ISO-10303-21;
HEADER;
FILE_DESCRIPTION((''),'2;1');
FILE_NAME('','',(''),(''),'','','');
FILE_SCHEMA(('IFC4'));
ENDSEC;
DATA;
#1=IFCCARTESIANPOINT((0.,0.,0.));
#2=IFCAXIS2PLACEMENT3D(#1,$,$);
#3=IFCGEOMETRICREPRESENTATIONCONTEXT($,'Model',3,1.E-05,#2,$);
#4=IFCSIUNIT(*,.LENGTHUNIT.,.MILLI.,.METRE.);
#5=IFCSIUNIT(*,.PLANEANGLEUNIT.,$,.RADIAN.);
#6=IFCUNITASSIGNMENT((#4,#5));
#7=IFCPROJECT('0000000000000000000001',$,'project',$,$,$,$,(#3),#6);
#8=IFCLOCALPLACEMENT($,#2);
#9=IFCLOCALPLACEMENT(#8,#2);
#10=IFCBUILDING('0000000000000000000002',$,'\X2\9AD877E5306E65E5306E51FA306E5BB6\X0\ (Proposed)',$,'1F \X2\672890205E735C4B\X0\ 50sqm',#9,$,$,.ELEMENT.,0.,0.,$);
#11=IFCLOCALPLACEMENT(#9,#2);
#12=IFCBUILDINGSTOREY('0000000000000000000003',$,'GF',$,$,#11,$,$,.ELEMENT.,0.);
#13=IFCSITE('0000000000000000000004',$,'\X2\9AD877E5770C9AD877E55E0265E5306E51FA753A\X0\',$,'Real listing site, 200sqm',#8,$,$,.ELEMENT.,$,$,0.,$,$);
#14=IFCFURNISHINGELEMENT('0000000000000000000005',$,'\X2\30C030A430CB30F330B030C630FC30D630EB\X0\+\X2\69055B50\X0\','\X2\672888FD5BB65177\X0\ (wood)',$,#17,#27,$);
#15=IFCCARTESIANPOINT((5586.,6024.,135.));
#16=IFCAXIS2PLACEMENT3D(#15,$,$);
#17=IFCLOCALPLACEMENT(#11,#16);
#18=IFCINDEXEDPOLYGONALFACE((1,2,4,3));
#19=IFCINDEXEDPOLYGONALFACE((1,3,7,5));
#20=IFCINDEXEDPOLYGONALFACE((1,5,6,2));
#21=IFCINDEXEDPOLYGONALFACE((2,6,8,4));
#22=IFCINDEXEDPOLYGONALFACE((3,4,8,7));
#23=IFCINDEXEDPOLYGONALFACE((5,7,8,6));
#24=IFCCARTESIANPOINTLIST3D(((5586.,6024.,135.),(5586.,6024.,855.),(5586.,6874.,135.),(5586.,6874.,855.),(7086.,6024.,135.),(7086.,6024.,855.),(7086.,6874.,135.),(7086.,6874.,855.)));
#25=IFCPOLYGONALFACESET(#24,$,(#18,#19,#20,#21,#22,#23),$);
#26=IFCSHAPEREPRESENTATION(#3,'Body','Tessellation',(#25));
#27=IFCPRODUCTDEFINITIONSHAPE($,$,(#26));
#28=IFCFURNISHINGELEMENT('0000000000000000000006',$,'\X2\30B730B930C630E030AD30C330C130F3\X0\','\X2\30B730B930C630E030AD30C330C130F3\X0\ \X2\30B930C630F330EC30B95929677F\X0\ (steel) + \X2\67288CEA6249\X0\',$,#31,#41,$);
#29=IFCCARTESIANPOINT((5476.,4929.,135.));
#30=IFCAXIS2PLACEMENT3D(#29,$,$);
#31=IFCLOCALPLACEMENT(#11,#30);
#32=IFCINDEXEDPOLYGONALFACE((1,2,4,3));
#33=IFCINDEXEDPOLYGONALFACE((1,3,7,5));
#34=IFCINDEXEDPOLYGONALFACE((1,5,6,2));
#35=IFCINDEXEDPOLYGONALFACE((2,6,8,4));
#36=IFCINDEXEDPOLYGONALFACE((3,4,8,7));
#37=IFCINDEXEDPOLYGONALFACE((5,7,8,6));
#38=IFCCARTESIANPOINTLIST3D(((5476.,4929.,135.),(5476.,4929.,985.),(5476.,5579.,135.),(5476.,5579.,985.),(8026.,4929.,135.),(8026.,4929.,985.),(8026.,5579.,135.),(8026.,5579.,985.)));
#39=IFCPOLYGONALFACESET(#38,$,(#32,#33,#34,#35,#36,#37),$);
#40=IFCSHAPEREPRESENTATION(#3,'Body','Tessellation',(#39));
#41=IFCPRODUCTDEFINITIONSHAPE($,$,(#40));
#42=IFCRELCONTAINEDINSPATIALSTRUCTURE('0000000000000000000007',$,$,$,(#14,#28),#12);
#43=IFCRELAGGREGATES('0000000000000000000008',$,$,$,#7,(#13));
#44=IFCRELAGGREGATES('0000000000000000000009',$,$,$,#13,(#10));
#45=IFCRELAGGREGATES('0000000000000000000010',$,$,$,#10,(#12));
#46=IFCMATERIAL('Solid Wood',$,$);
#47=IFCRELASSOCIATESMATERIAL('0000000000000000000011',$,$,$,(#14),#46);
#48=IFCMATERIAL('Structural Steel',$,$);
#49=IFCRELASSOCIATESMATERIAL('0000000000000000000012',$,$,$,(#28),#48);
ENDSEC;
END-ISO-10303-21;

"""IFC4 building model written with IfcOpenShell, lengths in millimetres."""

from ifc_helpers import new_model, si_unit, frame, frame_2d, origin, place, context, project, spatial, rectangle, extrude, material, element, save


model = new_model("IFC4")

# Units and contexts
model_context = context("Model", 3, precision=1e-05, world=origin())
ifc_project = project(units=[si_unit("LENGTHUNIT", "METRE", prefix="MILLI"), si_unit("PLANEANGLEUNIT", "RADIAN")], contexts=[model_context])

# Site, building, storey
site_placement = place(None, origin())
site = spatial("IfcSite", under=ifc_project, at=site_placement, Name="高知県高知市日の出町", ObjectType="Real listing site, 200sqm", CompositionType="ELEMENT", RefElevation=0.0)
building_placement = place(site_placement, origin())
building = spatial("IfcBuilding", under=site, at=building_placement, Name="高知の日の出の家 (Proposed)", ObjectType="1F 木造平屋 50sqm", CompositionType="ELEMENT", ElevationOfRefHeight=0.0, ElevationOfTerrain=0.0)
storey_placement = place(building_placement, origin())
storey = spatial("IfcBuildingStorey", under=building, at=storey_placement, Name="GF", CompositionType="ELEMENT", Elevation=0.0)

# Shared definitions
ifc_material_1 = material(Name="Solid Wood")

# Shared definitions
ifc_material_2 = material(Name="Structural Steel")

# Furnishing elements
furnishing_1_placement = place(storey_placement, frame((5586.0, 6024.0, 135.0)))
element("IfcFurnishingElement", 1, at=furnishing_1_placement, inside=storey, material=ifc_material_1, Name="ダイニングテーブル+椅子", Description="木製家具 (wood)", context=model_context, shape_type="SweptSolid", body=[
    extrude(rectangle(XDim=1500.0, YDim=850.0, at=frame_2d((750.0, 425.0))), frame((5586.0, 6024.0, 135.0)), (0.0, 0.0, 1.0), 720.0),
])
furnishing_2_placement = place(storey_placement, frame((5476.0, 4929.0, 135.0)))
element("IfcFurnishingElement", 2, at=furnishing_2_placement, inside=storey, material=ifc_material_2, Name="システムキッチン", Description="システムキッチン ステンレス天板 (steel) + 木質扉", context=model_context, shape_type="SweptSolid", body=[
    extrude(rectangle(XDim=2550.0, YDim=650.0, at=frame_2d((1275.0, 325.0))), frame((5476.0, 4929.0, 135.0)), (0.0, 0.0, 1.0), 850.0),
])

save(model, "model.ifc")
